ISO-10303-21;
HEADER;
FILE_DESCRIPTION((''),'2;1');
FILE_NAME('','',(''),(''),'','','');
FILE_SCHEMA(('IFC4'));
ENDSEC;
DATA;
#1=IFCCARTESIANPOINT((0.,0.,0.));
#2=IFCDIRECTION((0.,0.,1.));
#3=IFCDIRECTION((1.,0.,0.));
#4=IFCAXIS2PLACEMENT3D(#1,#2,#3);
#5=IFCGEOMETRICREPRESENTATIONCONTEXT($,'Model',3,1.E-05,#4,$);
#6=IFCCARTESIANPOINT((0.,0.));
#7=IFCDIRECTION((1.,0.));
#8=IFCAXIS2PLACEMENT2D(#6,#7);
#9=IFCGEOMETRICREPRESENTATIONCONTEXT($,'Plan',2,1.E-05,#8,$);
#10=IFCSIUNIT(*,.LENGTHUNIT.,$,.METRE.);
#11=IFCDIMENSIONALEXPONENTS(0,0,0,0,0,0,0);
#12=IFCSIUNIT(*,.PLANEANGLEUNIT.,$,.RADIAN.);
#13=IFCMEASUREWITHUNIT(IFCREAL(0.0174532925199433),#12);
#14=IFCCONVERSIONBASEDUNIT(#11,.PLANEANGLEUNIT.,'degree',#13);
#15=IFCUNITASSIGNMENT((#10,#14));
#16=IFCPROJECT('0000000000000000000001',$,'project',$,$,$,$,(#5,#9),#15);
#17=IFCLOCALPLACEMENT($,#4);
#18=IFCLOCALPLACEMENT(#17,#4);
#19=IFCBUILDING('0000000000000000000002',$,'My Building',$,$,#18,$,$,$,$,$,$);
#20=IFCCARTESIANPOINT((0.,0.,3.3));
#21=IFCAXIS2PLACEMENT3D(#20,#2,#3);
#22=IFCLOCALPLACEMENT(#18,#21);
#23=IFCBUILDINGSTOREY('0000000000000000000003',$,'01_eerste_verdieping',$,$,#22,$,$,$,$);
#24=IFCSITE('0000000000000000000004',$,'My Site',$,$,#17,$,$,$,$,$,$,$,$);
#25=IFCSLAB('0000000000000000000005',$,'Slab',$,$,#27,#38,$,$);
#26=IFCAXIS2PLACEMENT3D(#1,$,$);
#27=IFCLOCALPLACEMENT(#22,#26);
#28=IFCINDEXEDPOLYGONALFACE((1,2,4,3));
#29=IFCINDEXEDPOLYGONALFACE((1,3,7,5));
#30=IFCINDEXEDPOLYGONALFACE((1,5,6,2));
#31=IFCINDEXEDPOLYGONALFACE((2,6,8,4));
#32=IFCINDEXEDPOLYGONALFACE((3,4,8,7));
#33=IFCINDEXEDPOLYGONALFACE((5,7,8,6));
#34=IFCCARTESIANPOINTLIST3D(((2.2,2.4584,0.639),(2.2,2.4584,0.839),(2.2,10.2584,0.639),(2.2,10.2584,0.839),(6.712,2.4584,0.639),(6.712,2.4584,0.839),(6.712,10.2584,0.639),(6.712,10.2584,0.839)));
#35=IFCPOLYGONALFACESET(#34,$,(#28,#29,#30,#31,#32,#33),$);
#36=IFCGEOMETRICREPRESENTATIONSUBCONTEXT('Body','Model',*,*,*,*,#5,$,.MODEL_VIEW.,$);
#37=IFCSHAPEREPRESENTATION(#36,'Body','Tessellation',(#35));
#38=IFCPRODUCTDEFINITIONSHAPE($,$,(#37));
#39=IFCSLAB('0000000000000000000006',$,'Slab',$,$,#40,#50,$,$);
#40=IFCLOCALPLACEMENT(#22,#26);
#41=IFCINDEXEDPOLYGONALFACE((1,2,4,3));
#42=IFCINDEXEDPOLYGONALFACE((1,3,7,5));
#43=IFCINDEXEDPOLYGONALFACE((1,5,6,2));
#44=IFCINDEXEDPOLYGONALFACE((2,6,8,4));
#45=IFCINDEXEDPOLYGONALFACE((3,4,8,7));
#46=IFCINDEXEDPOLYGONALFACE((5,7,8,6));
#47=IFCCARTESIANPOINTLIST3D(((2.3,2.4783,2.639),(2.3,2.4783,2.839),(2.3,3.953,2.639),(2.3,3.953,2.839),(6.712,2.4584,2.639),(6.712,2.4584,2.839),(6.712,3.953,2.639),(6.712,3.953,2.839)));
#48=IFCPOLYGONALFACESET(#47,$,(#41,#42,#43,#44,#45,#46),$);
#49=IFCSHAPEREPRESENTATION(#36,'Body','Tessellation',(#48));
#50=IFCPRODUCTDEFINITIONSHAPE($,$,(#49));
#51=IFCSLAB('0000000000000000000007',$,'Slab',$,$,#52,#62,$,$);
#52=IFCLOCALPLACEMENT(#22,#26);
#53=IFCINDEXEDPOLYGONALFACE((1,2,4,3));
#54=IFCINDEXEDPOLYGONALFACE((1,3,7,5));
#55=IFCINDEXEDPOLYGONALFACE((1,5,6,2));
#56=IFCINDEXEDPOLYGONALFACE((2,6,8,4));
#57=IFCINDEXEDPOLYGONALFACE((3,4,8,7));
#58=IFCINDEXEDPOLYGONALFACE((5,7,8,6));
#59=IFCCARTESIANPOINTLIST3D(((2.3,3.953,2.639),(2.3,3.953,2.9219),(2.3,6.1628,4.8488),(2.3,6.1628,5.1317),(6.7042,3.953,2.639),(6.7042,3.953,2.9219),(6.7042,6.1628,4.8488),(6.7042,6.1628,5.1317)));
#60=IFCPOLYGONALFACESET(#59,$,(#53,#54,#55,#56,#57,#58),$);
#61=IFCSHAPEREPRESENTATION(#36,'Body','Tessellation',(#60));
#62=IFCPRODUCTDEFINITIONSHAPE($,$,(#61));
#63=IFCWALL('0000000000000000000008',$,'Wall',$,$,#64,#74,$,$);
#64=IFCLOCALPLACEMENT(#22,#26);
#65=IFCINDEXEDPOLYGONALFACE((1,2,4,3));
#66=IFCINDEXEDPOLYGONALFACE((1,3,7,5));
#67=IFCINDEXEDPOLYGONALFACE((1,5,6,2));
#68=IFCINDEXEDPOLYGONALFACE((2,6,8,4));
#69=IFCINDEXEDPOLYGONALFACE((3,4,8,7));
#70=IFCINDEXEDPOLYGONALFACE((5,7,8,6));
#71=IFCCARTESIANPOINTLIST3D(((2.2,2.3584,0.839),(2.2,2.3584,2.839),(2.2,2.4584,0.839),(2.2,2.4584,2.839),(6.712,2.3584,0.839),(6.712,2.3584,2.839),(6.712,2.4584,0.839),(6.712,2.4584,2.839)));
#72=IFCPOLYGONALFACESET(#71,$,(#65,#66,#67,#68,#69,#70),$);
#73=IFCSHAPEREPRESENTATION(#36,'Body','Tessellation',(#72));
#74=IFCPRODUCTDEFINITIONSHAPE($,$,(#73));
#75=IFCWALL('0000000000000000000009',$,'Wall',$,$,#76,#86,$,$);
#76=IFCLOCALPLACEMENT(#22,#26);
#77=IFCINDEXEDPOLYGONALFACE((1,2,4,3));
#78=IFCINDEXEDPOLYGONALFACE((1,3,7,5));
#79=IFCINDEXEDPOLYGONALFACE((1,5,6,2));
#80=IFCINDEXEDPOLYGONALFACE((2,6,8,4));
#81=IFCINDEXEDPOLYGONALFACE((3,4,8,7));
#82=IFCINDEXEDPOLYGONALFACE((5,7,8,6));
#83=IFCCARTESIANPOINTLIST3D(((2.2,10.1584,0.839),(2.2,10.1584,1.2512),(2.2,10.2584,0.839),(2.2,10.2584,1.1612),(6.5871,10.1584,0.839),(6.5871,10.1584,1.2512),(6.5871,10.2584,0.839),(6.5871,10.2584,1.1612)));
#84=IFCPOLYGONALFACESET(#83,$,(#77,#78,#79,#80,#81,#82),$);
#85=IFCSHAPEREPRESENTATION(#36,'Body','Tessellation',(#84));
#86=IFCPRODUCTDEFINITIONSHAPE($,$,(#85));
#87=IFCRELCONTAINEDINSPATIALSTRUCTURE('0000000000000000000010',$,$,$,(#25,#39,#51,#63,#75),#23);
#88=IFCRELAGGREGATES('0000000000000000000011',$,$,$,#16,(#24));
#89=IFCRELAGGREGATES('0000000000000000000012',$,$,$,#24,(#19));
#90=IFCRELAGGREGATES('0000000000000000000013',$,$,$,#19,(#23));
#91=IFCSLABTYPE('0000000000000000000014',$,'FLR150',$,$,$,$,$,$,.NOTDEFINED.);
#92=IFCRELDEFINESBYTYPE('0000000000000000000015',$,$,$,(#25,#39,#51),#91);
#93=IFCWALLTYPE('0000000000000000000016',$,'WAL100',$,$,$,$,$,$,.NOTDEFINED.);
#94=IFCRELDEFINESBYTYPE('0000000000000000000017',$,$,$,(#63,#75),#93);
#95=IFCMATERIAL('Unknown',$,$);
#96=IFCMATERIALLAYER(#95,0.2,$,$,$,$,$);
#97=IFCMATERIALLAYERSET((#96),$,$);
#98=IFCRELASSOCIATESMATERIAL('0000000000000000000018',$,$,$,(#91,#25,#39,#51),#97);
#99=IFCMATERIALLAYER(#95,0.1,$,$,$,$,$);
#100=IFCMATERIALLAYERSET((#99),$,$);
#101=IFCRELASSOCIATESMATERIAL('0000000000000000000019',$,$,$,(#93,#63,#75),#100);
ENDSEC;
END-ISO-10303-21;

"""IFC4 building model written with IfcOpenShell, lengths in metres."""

from ifc_helpers import new_model, entity, si_unit, converted_unit, frame, origin_with_axes, origin_2d_with_axis, place, context, subcontext, project, spatial, line, indexed_curve, outline, extrude, clip, halfspace, material, layer, layer_set, layer_usage, type_object, element, save


model = new_model("IFC4")

# Units and contexts
model_context = context("Model", 3, precision=1e-05, world=origin_with_axes())
plan_context = context("Plan", 2, precision=1e-05, world=origin_2d_with_axis())
body_context_1 = subcontext(model_context, "Body", "Model", "MODEL_VIEW")
ifc_project = project(units=[si_unit("LENGTHUNIT", "METRE"), converted_unit("PLANEANGLEUNIT", "degree", entity("IfcReal", 0.0174532925199433), si_unit("PLANEANGLEUNIT", "RADIAN"), dimensions=[0, 0, 0, 0, 0, 0, 0])], contexts=[model_context, plan_context])

# Site, building, storey
site_placement = place(None, origin_with_axes())
site = spatial("IfcSite", under=ifc_project, at=site_placement, Name="My Site")
building_placement = place(site_placement, origin_with_axes())
building = spatial("IfcBuilding", under=site, at=building_placement, Name="My Building")
storey_placement = place(building_placement, frame((0.0, 0.0, 3.3), z_axis=(0.0, 0.0, 1.0), x_axis=(1.0, 0.0, 0.0)))
storey = spatial("IfcBuildingStorey", under=building, at=storey_placement, Name="01_eerste_verdieping")

# Slabs
ifc_material = material(Name="Unknown")
ifc_layer_1 = layer(ifc_material, 0.2)
ifc_layer_set_1 = layer_set([ifc_layer_1])
ifc_layer_usage_1 = layer_usage(ifc_layer_set_1, "AXIS3", "POSITIVE", 0.0)
slab_type_1 = type_object("IfcSlabType", Name="FLR150", PredefinedType="NOTDEFINED", material=ifc_layer_set_1)
slab_1_placement = place(storey_placement, frame((2.2, 2.4584, 0.639), z_axis=(0.0, 0.0, 1.0), x_axis=(1.0, 0.0, 0.0)))
element("IfcSlab", 1, at=slab_1_placement, inside=storey, type_object=slab_type_1, material=ifc_layer_usage_1, Name="Slab", context=body_context_1, shape_type="SweptSolid", body=[
    extrude(outline(indexed_curve([(4.512, 7.8), (4.512, 0.0), (0.0, 0.0), (0.0, 7.8)], segments=[line(3, 2), line(2, 1), line(1, 4), line(4, 3)], self_intersect=False)), None, (0.0, 0.0, 1.0), 0.2),
])
ifc_layer_usage_2 = layer_usage(ifc_layer_set_1, "AXIS3", "POSITIVE", 0.0)
slab_2_placement = place(storey_placement, frame((2.3, 2.4783, 2.639), z_axis=(0.0, 0.0, 1.0), x_axis=(1.0, 0.0, 0.0)))
element("IfcSlab", 2, at=slab_2_placement, inside=storey, type_object=slab_type_1, material=ifc_layer_usage_2, Name="Slab", context=body_context_1, shape_type="SweptSolid", body=[
    extrude(outline(indexed_curve([(0.0, 1.4747), (0.0, 0.0), (4.412, -0.0199), (4.412, 1.4747)], segments=[line(4, 1), line(1, 2), line(2, 3), line(3, 4)], self_intersect=False)), None, (0.0, 0.0, 1.0), 0.2),
])
ifc_layer_usage_3 = layer_usage(ifc_layer_set_1, "AXIS3", "POSITIVE", 0.0)
slab_3_placement = place(storey_placement, frame((2.3, 3.953, 2.639), z_axis=(0.0, -0.707107, 0.707107), x_axis=(1.0, 0.0, 0.0)))
element("IfcSlab", 3, at=slab_3_placement, inside=storey, type_object=slab_type_1, material=ifc_layer_usage_3, Name="Slab", context=body_context_1, shape_type="SweptSolid", body=[
    extrude(outline(indexed_curve([(4.4042, 0.0), (0.0, 0.0), (0.0, 3.1252), (4.4042, 3.1252)], segments=[line(4, 1), line(1, 2), line(2, 3), line(3, 4)], self_intersect=False)), None, (0.0, 0.707107, 0.707107), 0.2828),
])

# Walls
ifc_layer_2 = layer(ifc_material, 0.1)
ifc_layer_set_2 = layer_set([ifc_layer_2])
ifc_layer_usage_4 = layer_usage(ifc_layer_set_2, "AXIS2", "POSITIVE", 0.0)
wall_type_1 = type_object("IfcWallType", Name="WAL100", PredefinedType="NOTDEFINED", material=ifc_layer_set_2)
wall_1_placement = place(storey_placement, frame((2.2, 2.3584, 0.839), z_axis=(0.0, 0.0, 1.0), x_axis=(1.0, 0.0, 0.0)))
element("IfcWall", 4, at=wall_1_placement, inside=storey, type_object=wall_type_1, material=ifc_layer_usage_4, Name="Wall", context=body_context_1, shape_type="SweptSolid", body=[
    extrude(outline(indexed_curve([(0.0, 0.0), (0.0, 0.1), (4.512, 0.1), (4.512, 0.0), (0.0, 0.0)], self_intersect=False)), origin_with_axes(), (0.0, 0.0, 1.0), 2.0),
])
ifc_layer_usage_5 = layer_usage(ifc_layer_set_2, "AXIS2", "POSITIVE", 0.0)
wall_2_placement = place(storey_placement, frame((6.5871, 10.2584, 0.839), z_axis=(0.0, 0.0, 1.0), x_axis=(-1.0, 0.0, 0.0)))
element("IfcWall", 5, at=wall_2_placement, inside=storey, type_object=wall_type_1, material=ifc_layer_usage_5, Name="Wall", context=body_context_1, shape_type="Clipping", body=[
    clip(extrude(outline(indexed_curve([(0.0, 0.0), (0.0, 0.1), (4.3871, 0.1), (4.3871, 0.0), (0.0, 0.0)], self_intersect=False)), origin_with_axes(), (0.0, 0.0, 1.0), 4.5512), halfspace(frame((0.0, 0.1, 0.4122), z_axis=(0.0, -0.669131, 0.743145), x_axis=(-1.0, 0.0, 0.0)), False)),
])

save(model, "model.ifc")
